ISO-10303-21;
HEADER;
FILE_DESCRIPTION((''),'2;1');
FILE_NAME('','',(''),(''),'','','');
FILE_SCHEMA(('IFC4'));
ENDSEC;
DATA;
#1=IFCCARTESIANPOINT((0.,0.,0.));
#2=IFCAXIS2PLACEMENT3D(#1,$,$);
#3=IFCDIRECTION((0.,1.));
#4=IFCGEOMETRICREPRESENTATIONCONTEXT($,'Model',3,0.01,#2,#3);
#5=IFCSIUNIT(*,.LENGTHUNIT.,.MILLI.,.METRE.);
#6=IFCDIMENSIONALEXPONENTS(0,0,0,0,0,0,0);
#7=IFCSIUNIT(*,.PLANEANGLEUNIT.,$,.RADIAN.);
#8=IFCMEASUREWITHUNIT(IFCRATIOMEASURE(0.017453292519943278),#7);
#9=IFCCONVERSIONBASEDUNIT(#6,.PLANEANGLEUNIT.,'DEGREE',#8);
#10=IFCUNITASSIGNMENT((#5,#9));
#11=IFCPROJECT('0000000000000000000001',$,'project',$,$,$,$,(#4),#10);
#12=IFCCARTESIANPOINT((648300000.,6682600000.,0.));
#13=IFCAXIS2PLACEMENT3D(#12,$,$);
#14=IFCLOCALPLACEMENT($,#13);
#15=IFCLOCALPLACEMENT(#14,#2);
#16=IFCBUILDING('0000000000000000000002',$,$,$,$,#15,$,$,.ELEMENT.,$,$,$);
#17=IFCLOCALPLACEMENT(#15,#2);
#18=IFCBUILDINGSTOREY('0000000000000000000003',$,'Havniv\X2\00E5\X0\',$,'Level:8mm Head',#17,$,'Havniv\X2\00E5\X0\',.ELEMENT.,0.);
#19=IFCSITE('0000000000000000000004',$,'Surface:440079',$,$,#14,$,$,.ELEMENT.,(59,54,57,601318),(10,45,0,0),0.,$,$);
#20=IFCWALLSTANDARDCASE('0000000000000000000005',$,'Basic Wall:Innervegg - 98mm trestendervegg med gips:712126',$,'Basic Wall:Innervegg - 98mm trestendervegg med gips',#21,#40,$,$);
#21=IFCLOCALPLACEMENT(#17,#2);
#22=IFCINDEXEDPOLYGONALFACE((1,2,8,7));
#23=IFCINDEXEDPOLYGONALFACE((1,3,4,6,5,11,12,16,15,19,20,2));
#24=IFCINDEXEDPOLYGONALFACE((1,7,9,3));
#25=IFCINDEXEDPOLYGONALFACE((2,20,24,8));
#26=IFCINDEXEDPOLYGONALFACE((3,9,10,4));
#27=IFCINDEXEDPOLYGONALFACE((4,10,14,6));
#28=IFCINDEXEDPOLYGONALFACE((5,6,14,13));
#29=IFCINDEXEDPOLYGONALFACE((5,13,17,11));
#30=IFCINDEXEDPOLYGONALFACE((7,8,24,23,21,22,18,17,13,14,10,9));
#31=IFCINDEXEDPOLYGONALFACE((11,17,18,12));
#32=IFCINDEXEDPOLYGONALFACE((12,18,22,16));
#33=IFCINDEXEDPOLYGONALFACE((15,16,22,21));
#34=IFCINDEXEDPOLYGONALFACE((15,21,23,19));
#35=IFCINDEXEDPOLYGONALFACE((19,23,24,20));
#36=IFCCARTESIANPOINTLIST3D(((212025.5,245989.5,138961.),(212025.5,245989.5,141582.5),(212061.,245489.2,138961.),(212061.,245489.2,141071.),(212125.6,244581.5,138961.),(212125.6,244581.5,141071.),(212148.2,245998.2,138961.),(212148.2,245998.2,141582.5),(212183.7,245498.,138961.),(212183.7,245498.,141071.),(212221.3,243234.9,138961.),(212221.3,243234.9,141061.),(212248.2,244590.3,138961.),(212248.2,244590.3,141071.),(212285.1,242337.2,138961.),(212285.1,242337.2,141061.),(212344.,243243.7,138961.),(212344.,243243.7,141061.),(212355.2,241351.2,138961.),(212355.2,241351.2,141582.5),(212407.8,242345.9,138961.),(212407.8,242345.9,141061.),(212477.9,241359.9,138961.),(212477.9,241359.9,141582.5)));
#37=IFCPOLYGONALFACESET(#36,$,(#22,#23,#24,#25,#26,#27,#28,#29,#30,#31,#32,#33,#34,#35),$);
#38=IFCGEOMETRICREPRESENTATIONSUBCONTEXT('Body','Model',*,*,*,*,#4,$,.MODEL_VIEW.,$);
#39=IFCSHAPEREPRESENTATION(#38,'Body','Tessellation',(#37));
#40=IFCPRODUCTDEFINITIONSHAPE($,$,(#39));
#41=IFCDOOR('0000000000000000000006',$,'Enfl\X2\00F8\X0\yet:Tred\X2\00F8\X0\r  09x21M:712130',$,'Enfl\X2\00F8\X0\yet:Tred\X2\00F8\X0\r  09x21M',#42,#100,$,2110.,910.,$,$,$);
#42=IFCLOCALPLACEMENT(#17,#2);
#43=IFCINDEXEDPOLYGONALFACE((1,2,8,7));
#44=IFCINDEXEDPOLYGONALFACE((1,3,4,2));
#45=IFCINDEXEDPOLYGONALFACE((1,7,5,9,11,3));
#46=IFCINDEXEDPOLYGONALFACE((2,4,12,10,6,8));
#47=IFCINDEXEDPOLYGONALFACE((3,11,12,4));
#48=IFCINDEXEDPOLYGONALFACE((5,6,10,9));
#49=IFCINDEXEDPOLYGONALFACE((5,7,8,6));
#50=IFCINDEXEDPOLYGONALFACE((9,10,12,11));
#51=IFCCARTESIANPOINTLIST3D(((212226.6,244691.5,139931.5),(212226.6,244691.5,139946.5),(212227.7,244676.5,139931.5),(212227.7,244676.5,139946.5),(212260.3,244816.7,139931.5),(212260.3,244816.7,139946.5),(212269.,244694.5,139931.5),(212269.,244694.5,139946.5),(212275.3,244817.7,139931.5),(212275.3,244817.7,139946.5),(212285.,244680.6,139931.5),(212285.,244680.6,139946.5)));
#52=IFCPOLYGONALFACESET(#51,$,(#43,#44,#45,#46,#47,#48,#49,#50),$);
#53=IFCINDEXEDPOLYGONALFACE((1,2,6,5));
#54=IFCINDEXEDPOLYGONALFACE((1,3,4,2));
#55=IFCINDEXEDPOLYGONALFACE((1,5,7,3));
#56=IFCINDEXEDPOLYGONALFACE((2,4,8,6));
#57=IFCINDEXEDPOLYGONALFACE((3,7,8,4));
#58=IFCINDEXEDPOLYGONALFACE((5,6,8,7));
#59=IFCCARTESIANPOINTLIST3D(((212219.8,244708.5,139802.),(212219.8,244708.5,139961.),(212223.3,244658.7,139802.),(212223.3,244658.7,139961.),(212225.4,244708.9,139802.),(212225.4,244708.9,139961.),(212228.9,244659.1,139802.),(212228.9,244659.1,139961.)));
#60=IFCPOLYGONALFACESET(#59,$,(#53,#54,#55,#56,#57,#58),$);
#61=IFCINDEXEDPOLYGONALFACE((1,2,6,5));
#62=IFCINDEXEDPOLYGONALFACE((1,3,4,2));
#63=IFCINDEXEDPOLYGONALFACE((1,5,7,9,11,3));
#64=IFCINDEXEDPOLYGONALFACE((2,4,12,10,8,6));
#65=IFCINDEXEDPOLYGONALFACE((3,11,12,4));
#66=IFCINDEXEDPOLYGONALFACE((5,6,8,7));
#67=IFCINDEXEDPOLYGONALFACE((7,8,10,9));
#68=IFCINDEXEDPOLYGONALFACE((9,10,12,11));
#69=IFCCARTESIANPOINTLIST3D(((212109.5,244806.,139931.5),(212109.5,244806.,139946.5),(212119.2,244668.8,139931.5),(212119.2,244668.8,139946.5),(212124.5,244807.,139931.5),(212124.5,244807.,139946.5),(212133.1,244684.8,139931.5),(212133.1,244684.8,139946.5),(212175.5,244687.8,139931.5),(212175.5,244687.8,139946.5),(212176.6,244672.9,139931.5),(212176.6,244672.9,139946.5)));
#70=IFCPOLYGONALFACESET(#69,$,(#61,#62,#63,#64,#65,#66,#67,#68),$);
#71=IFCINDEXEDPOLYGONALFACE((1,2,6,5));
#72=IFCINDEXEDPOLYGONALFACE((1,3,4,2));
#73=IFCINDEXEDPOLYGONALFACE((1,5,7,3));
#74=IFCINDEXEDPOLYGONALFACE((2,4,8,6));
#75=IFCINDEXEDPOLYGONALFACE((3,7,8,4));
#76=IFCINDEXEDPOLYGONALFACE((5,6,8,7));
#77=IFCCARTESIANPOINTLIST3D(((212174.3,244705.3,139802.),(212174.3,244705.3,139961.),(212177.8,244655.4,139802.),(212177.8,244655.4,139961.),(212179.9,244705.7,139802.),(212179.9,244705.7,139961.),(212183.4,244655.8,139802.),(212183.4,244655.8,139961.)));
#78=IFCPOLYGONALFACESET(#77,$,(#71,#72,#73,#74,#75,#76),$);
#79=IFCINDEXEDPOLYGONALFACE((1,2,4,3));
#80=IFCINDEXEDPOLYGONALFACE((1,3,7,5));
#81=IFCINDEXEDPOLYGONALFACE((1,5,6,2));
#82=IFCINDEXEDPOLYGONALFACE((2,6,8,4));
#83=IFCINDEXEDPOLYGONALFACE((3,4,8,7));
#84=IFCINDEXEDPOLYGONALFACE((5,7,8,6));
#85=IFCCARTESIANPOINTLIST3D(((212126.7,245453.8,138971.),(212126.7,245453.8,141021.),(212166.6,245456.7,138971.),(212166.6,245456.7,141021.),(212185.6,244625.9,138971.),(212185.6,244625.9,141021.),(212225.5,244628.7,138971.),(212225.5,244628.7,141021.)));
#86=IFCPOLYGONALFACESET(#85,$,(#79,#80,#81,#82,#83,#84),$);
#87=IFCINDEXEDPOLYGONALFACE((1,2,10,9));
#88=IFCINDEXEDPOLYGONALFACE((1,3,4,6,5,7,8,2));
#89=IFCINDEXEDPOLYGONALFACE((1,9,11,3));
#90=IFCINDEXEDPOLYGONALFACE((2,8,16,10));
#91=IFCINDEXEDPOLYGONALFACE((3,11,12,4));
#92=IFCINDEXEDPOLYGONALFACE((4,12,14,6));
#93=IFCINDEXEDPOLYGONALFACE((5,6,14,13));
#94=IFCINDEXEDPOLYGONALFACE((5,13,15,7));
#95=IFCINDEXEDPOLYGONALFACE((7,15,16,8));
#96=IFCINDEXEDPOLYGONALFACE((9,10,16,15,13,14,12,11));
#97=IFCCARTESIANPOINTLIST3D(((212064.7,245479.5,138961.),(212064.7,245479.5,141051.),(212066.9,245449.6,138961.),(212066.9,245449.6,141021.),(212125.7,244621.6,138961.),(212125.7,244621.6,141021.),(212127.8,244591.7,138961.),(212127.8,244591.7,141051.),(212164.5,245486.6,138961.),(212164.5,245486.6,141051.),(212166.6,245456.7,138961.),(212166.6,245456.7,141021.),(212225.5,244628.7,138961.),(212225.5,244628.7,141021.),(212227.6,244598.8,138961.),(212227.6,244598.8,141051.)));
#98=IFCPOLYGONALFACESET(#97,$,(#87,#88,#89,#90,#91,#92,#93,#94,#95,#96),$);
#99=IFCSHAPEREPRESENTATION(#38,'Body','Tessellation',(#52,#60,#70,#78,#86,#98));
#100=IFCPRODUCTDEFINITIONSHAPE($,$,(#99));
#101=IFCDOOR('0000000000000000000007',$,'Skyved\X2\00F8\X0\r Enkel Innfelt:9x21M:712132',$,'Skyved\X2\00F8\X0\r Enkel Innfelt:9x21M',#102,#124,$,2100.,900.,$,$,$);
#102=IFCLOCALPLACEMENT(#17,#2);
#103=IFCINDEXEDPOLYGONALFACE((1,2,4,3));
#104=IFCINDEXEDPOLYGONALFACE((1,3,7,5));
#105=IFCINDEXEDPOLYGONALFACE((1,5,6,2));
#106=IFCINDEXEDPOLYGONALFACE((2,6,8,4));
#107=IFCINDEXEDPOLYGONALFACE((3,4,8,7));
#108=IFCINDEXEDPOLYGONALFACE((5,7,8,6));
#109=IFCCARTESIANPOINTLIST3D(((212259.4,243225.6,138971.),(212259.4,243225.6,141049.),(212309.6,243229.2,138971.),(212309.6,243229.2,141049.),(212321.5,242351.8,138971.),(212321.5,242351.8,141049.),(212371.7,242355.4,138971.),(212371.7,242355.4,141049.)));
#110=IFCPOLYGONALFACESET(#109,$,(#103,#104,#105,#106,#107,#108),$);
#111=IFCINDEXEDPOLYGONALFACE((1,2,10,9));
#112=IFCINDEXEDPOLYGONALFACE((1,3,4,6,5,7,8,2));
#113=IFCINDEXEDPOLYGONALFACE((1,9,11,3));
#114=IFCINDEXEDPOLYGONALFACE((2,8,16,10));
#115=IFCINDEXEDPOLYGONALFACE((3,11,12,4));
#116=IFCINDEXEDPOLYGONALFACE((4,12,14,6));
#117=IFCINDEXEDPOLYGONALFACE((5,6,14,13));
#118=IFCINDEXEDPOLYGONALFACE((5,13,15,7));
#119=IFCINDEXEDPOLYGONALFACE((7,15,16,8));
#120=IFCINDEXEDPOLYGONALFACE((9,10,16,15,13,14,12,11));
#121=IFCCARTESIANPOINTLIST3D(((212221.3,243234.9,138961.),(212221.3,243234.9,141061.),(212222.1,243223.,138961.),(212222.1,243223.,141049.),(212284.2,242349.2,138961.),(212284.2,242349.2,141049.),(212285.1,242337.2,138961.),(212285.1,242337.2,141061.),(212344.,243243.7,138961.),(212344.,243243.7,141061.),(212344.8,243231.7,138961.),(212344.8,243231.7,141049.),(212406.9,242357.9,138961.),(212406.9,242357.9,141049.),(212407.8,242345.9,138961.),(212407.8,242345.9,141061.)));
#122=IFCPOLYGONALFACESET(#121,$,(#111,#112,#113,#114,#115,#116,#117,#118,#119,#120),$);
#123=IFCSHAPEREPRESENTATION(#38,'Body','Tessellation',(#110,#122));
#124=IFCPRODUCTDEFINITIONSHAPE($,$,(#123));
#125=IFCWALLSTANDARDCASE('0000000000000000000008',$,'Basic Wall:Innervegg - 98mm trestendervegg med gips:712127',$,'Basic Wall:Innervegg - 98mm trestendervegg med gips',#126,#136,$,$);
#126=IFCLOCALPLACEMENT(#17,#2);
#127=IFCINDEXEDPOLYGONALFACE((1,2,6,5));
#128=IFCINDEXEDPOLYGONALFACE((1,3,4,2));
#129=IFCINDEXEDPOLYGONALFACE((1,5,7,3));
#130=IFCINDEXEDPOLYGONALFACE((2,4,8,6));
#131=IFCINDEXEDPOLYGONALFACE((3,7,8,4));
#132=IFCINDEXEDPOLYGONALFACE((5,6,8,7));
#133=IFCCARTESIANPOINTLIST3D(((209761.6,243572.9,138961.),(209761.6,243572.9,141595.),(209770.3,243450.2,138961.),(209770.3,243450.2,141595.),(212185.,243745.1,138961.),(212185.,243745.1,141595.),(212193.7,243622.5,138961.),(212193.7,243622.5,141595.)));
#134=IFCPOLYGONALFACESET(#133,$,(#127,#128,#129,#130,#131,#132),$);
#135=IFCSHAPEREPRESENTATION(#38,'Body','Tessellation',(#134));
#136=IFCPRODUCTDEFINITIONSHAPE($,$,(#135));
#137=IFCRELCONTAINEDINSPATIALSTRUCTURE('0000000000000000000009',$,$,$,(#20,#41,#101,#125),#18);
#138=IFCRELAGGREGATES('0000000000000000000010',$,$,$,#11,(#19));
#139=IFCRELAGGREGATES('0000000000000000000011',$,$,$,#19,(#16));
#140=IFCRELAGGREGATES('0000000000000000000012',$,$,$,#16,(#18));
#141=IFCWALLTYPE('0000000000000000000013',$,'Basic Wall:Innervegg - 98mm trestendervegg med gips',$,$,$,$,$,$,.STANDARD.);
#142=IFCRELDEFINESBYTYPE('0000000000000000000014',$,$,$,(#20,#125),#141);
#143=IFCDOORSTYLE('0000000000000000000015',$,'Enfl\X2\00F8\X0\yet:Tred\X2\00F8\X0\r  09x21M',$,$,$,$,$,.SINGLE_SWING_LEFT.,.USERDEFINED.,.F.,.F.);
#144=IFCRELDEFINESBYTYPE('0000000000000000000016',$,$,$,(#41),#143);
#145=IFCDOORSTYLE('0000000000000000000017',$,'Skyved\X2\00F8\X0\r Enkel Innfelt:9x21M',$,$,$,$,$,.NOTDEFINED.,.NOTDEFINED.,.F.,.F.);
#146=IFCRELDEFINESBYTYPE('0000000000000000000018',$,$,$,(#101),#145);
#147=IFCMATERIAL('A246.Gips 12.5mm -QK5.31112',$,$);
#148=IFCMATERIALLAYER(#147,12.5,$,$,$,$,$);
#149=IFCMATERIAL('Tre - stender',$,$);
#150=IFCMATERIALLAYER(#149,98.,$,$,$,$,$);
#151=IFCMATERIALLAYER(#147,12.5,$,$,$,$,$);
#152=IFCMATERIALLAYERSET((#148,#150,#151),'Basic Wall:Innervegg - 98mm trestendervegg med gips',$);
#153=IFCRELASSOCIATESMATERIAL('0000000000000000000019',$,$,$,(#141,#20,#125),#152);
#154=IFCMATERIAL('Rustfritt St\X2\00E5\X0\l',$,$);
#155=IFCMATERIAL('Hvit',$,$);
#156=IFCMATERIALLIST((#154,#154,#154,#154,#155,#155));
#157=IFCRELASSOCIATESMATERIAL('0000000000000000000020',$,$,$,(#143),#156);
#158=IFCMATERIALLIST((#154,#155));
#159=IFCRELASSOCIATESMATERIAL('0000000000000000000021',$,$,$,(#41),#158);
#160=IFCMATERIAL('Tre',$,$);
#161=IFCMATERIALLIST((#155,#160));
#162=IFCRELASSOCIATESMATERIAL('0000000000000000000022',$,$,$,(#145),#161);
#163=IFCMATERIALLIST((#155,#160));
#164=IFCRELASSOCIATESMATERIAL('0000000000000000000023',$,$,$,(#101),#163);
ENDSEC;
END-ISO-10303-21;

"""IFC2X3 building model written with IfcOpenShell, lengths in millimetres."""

from ifc_helpers import new_model, entity, si_unit, converted_unit, direction, frame, frame_2d, origin, origin_2d_with_axis, place, context, subcontext, project, spatial, polyline, rectangle, outline, extrude, clip, bounded_halfspace, source, transform, mapped, material, material_list, layer, layer_set, layer_usage, type_object, type_shapes, element, fill, save


model = new_model("IFC2X3")

# Units and contexts
model_context = context("Model", 3, precision=0.01, world=origin(), true_north=direction((0.0, 1.0)))
body_context = subcontext(model_context, "Body", "Model", "MODEL_VIEW")
ifc_project = project(units=[si_unit("LENGTHUNIT", "METRE", prefix="MILLI"), converted_unit("PLANEANGLEUNIT", "DEGREE", entity("IfcRatioMeasure", 0.017453292519943278), si_unit("PLANEANGLEUNIT", "RADIAN"), dimensions=[0, 0, 0, 0, 0, 0, 0])], contexts=[model_context])

# Site, building, storey
site_placement = place(None, frame((648300000.0, 6682600000.0, 0.0)))
site = spatial("IfcSite", under=ifc_project, at=site_placement, Name="Surface:440079", CompositionType="ELEMENT", RefLatitude=(59, 54, 57, 601318), RefLongitude=(10, 45, 0, 0), RefElevation=0.0)
building_placement = place(site_placement, origin())
building = spatial("IfcBuilding", under=site, at=building_placement, CompositionType="ELEMENT")
storey_placement = place(building_placement, origin())
storey = spatial("IfcBuildingStorey", under=building, at=storey_placement, Name="Havnivå", ObjectType="Level:8mm Head", LongName="Havnivå", CompositionType="ELEMENT", Elevation=0.0)

# Shared definitions
ifc_material_1 = material(Name="A246.Gips 12.5mm -QK5.31112")

# Wall, openings, doors
ifc_layer_1 = layer(ifc_material_1, 12.5)
ifc_material_2 = material(Name="Tre - stender")
ifc_layer_2 = layer(ifc_material_2, 98.0)
ifc_layer_3 = layer(ifc_material_1, 12.5)
ifc_layer_set_1 = layer_set([ifc_layer_1, ifc_layer_2, ifc_layer_3], Name="Basic Wall:Innervegg - 98mm trestendervegg med gips")
wall_type_1 = type_object("IfcWallType", Name="Basic Wall:Innervegg - 98mm trestendervegg med gips", PredefinedType="STANDARD", material=ifc_layer_set_1)
ifc_material_3 = material(Name="Rustfritt Stål")
ifc_material_4 = material(Name="Hvit")
ifc_material_list_1 = material_list([ifc_material_3, ifc_material_3, ifc_material_3, ifc_material_3, ifc_material_4, ifc_material_4])
door_style_1 = type_object("IfcDoorStyle", Name="Enfløyet:Tredør  09x21M", ConstructionType="USERDEFINED", OperationType="SINGLE_SWING_LEFT", ParameterTakesPrecedence=False, Sizeable=False, material=ifc_material_list_1)
shared_shape_1 = source(origin(), body_context, "Body", "SweptSolid", [
    extrude(outline(polyline([(-33.3, -50.8), (24.2, -50.8), (24.2, 86.7), (9.2, 86.7), (9.2, -35.8), (-33.3, -35.8), (-33.3, -50.8)])), frame((771.7, 121.9, 970.5), z_axis=(0.0, 0.0, 1.0), x_axis=(0.0, 1.0, 0.0)), (0.0, 0.0, 1.0), 15.0),
    extrude(rectangle(XDim=5.6, YDim=50.0, at=frame_2d((0.0, 0.0), x_axis=(1.0, 0.0))), frame((815.0, 85.8, 841.0), z_axis=(0.0, 0.0, 1.0), x_axis=(0.0, -1.0, 0.0)), (0.0, 0.0, 1.0), 159.0),
    extrude(outline(polyline([(-50.8, -33.3), (-35.8, -33.3), (-35.8, 9.2), (86.7, 9.2), (86.7, 24.2), (-50.8, 24.2), (-50.8, -33.3)])), frame((771.7, 4.1, 970.5), z_axis=(0.0, 0.0, 1.0), x_axis=(-1.0, 0.0, 0.0)), (0.0, 0.0, 1.0), 15.0),
    extrude(rectangle(XDim=50.0, YDim=5.6, at=frame_2d((0.0, 0.0), x_axis=(1.0, 0.0))), frame((815.0, 40.2, 841.0)), (0.0, 0.0, 1.0), 159.0),
    extrude(rectangle(XDim=830.0, YDim=40.0, at=origin_2d_with_axis()), frame((455.0, 63.0, 10.0), z_axis=(0.0, 0.0, 1.0), x_axis=(-1.0, 0.0, 0.0)), (0.0, 0.0, 1.0), 2050.0),
    extrude(outline(polyline([(415.0, -1037.5), (445.0, -1037.5), (445.0, 1052.5), (-445.0, 1052.5), (-445.0, -1037.5), (-415.0, -1037.5), (-415.0, 1022.5), (415.0, 1022.5), (415.0, -1037.5)])), frame((455.0, 83.0, 1037.5), z_axis=(0.0, -1.0, 0.0), x_axis=(1.0, 0.0, 0.0)), (0.0, 0.0, 1.0), 100.0),
])
type_shapes(door_style_1, [shared_shape_1])
ifc_layer_usage_1 = layer_usage(ifc_layer_set_1, "AXIS2", "POSITIVE", -61.5)
wall_1_placement = place(storey_placement, frame((212416.5, 241355.5, 138961.0), z_axis=(0.0, 0.0, 1.0), x_axis=(-0.070908, 0.997483, 0.0)))
wall_1 = element("IfcWallStandardCase", 1, at=wall_1_placement, inside=storey, type_object=wall_type_1, material=ifc_layer_usage_1, Name="Basic Wall:Innervegg - 98mm trestendervegg med gips:712126", ObjectType="Basic Wall:Innervegg - 98mm trestendervegg med gips", context=body_context, shape_type="Clipping", body=[
    clip(extrude(rectangle(XDim=4650.0, YDim=123.0, at=frame_2d((2325.0, 0.0), x_axis=(1.0, 0.0))), origin(), (0.0, 0.0, 1.0), 2621.5), bounded_halfspace(frame((0.0, -61.5, 2621.5), z_axis=(0.0, 0.0, -1.0), x_axis=(0.0, 1.0, 0.0)), True, frame((0.0, -61.5, 2621.5)), polyline([(0.0, 0.0), (1417320.0, 0.0), (1417320.0, 37490.4), (91440.0, 37490.4), (53949.6, 37490.4), (0.0, 37490.4), (0.0, 0.0)]))),
])
opening_1_placement = place(wall_1_placement, frame((4148.5, 61.5, 0.0)))
opening_1 = element("IfcOpeningElement", 2, at=opening_1_placement, cuts=wall_1, ObjectType="Opening", context=body_context, shape_type="SweptSolid", body=[
    extrude(rectangle(XDim=2110.0, YDim=910.0, at=frame_2d((1055.0, 455.0), x_axis=(1.0, 0.0))), frame((0.0, 0.0, 0.0), z_axis=(0.0, -1.0, 0.0), x_axis=(0.0, 0.0, 1.0)), (0.0, 0.0, 1.0), 123.0),
])
opening_2_placement = place(wall_1_placement, frame((1888.5, 61.5, 0.0)))
opening_2 = element("IfcOpeningElement", 3, at=opening_2_placement, cuts=wall_1, ObjectType="Opening", context=body_context, shape_type="SweptSolid", body=[
    extrude(rectangle(XDim=2100.0, YDim=900.0, at=frame_2d((1050.0, 450.0), x_axis=(1.0, 0.0))), frame((0.0, 0.0, 0.0), z_axis=(0.0, -1.0, 0.0), x_axis=(0.0, 0.0, 1.0)), (0.0, 0.0, 1.0), 123.0),
])
ifc_material_list_2 = material_list([ifc_material_3, ifc_material_4])
door_1_placement = place(opening_1_placement, frame((0.0, -20.0, 0.0), z_axis=(0.0, 0.0, 1.0), x_axis=(-1.0, 0.0, 0.0)))
door_1 = element("IfcDoor", 4, at=door_1_placement, inside=storey, type_object=door_style_1, material=ifc_material_list_2, Name="Enfløyet:Tredør  09x21M:712130", ObjectType="Enfløyet:Tredør  09x21M", OverallHeight=2110.0, OverallWidth=910.0, context=body_context, shape_type="MappedRepresentation", body=[
    mapped(shared_shape_1, transform((0.0, 0.0, 0.0), scale=1.0)),
])
fill(opening_1, door_1)
ifc_material_5 = material(Name="Tre")
ifc_material_list_3 = material_list([ifc_material_4, ifc_material_5])
ifc_material_list_4 = material_list([ifc_material_4, ifc_material_5])
door_style_2 = type_object("IfcDoorStyle", Name="Skyvedør Enkel Innfelt:9x21M", ConstructionType="NOTDEFINED", OperationType="NOTDEFINED", ParameterTakesPrecedence=False, Sizeable=False, material=ifc_material_list_4)
shared_shape_2 = source(origin(), body_context, "Body", "SweptSolid", [
    extrude(rectangle(XDim=876.0, YDim=50.4, at=frame_2d((0.0, 0.0), x_axis=(1.0, 0.0))), frame((450.0, 62.5, 10.0), z_axis=(0.0, 0.0, 1.0), x_axis=(-1.0, 0.0, 0.0)), (0.0, 0.0, 1.0), 2078.0),
    extrude(outline(polyline([(-1047.0, -438.0), (-1047.0, -450.0), (1053.0, -450.0), (1053.0, 450.0), (-1047.0, 450.0), (-1047.0, 438.0), (1041.0, 438.0), (1041.0, -438.0), (-1047.0, -438.0)])), frame((450.0, 0.0, 1047.0), z_axis=(0.0, -1.0, 0.0), x_axis=(0.0, 0.0, 1.0)), (0.0, 0.0, -1.0), 123.0),
])
type_shapes(door_style_2, [shared_shape_2])
door_2_placement = place(opening_2_placement, frame((0.0, 0.0, 0.0), z_axis=(0.0, 0.0, 1.0), x_axis=(-1.0, 0.0, 0.0)))
door_2 = element("IfcDoor", 5, at=door_2_placement, inside=storey, type_object=door_style_2, material=ifc_material_list_3, Name="Skyvedør Enkel Innfelt:9x21M:712132", ObjectType="Skyvedør Enkel Innfelt:9x21M", OverallHeight=2100.0, OverallWidth=900.0, context=body_context, shape_type="MappedRepresentation", body=[
    mapped(shared_shape_2, transform((0.0, 0.0, 0.0), scale=1.0)),
])
fill(opening_2, door_2)

# Wall
ifc_layer_usage_2 = layer_usage(ifc_layer_set_1, "AXIS2", "NEGATIVE", 61.5)
wall_2_placement = place(storey_placement, frame((212189.4, 243683.8, 138961.0), z_axis=(0.0, 0.0, 1.0), x_axis=(-0.997483, -0.070908, 0.0)))
element("IfcWallStandardCase", 6, at=wall_2_placement, inside=storey, type_object=wall_type_1, material=ifc_layer_usage_2, Name="Basic Wall:Innervegg - 98mm trestendervegg med gips:712127", ObjectType="Basic Wall:Innervegg - 98mm trestendervegg med gips", context=body_context, shape_type="SweptSolid", body=[
    extrude(rectangle(XDim=2429.5, YDim=123.0, at=frame_2d((1214.8, 0.0), x_axis=(-1.0, 0.0))), origin(), (0.0, 0.0, 1.0), 2634.0),
])

save(model, "model.ifc")
